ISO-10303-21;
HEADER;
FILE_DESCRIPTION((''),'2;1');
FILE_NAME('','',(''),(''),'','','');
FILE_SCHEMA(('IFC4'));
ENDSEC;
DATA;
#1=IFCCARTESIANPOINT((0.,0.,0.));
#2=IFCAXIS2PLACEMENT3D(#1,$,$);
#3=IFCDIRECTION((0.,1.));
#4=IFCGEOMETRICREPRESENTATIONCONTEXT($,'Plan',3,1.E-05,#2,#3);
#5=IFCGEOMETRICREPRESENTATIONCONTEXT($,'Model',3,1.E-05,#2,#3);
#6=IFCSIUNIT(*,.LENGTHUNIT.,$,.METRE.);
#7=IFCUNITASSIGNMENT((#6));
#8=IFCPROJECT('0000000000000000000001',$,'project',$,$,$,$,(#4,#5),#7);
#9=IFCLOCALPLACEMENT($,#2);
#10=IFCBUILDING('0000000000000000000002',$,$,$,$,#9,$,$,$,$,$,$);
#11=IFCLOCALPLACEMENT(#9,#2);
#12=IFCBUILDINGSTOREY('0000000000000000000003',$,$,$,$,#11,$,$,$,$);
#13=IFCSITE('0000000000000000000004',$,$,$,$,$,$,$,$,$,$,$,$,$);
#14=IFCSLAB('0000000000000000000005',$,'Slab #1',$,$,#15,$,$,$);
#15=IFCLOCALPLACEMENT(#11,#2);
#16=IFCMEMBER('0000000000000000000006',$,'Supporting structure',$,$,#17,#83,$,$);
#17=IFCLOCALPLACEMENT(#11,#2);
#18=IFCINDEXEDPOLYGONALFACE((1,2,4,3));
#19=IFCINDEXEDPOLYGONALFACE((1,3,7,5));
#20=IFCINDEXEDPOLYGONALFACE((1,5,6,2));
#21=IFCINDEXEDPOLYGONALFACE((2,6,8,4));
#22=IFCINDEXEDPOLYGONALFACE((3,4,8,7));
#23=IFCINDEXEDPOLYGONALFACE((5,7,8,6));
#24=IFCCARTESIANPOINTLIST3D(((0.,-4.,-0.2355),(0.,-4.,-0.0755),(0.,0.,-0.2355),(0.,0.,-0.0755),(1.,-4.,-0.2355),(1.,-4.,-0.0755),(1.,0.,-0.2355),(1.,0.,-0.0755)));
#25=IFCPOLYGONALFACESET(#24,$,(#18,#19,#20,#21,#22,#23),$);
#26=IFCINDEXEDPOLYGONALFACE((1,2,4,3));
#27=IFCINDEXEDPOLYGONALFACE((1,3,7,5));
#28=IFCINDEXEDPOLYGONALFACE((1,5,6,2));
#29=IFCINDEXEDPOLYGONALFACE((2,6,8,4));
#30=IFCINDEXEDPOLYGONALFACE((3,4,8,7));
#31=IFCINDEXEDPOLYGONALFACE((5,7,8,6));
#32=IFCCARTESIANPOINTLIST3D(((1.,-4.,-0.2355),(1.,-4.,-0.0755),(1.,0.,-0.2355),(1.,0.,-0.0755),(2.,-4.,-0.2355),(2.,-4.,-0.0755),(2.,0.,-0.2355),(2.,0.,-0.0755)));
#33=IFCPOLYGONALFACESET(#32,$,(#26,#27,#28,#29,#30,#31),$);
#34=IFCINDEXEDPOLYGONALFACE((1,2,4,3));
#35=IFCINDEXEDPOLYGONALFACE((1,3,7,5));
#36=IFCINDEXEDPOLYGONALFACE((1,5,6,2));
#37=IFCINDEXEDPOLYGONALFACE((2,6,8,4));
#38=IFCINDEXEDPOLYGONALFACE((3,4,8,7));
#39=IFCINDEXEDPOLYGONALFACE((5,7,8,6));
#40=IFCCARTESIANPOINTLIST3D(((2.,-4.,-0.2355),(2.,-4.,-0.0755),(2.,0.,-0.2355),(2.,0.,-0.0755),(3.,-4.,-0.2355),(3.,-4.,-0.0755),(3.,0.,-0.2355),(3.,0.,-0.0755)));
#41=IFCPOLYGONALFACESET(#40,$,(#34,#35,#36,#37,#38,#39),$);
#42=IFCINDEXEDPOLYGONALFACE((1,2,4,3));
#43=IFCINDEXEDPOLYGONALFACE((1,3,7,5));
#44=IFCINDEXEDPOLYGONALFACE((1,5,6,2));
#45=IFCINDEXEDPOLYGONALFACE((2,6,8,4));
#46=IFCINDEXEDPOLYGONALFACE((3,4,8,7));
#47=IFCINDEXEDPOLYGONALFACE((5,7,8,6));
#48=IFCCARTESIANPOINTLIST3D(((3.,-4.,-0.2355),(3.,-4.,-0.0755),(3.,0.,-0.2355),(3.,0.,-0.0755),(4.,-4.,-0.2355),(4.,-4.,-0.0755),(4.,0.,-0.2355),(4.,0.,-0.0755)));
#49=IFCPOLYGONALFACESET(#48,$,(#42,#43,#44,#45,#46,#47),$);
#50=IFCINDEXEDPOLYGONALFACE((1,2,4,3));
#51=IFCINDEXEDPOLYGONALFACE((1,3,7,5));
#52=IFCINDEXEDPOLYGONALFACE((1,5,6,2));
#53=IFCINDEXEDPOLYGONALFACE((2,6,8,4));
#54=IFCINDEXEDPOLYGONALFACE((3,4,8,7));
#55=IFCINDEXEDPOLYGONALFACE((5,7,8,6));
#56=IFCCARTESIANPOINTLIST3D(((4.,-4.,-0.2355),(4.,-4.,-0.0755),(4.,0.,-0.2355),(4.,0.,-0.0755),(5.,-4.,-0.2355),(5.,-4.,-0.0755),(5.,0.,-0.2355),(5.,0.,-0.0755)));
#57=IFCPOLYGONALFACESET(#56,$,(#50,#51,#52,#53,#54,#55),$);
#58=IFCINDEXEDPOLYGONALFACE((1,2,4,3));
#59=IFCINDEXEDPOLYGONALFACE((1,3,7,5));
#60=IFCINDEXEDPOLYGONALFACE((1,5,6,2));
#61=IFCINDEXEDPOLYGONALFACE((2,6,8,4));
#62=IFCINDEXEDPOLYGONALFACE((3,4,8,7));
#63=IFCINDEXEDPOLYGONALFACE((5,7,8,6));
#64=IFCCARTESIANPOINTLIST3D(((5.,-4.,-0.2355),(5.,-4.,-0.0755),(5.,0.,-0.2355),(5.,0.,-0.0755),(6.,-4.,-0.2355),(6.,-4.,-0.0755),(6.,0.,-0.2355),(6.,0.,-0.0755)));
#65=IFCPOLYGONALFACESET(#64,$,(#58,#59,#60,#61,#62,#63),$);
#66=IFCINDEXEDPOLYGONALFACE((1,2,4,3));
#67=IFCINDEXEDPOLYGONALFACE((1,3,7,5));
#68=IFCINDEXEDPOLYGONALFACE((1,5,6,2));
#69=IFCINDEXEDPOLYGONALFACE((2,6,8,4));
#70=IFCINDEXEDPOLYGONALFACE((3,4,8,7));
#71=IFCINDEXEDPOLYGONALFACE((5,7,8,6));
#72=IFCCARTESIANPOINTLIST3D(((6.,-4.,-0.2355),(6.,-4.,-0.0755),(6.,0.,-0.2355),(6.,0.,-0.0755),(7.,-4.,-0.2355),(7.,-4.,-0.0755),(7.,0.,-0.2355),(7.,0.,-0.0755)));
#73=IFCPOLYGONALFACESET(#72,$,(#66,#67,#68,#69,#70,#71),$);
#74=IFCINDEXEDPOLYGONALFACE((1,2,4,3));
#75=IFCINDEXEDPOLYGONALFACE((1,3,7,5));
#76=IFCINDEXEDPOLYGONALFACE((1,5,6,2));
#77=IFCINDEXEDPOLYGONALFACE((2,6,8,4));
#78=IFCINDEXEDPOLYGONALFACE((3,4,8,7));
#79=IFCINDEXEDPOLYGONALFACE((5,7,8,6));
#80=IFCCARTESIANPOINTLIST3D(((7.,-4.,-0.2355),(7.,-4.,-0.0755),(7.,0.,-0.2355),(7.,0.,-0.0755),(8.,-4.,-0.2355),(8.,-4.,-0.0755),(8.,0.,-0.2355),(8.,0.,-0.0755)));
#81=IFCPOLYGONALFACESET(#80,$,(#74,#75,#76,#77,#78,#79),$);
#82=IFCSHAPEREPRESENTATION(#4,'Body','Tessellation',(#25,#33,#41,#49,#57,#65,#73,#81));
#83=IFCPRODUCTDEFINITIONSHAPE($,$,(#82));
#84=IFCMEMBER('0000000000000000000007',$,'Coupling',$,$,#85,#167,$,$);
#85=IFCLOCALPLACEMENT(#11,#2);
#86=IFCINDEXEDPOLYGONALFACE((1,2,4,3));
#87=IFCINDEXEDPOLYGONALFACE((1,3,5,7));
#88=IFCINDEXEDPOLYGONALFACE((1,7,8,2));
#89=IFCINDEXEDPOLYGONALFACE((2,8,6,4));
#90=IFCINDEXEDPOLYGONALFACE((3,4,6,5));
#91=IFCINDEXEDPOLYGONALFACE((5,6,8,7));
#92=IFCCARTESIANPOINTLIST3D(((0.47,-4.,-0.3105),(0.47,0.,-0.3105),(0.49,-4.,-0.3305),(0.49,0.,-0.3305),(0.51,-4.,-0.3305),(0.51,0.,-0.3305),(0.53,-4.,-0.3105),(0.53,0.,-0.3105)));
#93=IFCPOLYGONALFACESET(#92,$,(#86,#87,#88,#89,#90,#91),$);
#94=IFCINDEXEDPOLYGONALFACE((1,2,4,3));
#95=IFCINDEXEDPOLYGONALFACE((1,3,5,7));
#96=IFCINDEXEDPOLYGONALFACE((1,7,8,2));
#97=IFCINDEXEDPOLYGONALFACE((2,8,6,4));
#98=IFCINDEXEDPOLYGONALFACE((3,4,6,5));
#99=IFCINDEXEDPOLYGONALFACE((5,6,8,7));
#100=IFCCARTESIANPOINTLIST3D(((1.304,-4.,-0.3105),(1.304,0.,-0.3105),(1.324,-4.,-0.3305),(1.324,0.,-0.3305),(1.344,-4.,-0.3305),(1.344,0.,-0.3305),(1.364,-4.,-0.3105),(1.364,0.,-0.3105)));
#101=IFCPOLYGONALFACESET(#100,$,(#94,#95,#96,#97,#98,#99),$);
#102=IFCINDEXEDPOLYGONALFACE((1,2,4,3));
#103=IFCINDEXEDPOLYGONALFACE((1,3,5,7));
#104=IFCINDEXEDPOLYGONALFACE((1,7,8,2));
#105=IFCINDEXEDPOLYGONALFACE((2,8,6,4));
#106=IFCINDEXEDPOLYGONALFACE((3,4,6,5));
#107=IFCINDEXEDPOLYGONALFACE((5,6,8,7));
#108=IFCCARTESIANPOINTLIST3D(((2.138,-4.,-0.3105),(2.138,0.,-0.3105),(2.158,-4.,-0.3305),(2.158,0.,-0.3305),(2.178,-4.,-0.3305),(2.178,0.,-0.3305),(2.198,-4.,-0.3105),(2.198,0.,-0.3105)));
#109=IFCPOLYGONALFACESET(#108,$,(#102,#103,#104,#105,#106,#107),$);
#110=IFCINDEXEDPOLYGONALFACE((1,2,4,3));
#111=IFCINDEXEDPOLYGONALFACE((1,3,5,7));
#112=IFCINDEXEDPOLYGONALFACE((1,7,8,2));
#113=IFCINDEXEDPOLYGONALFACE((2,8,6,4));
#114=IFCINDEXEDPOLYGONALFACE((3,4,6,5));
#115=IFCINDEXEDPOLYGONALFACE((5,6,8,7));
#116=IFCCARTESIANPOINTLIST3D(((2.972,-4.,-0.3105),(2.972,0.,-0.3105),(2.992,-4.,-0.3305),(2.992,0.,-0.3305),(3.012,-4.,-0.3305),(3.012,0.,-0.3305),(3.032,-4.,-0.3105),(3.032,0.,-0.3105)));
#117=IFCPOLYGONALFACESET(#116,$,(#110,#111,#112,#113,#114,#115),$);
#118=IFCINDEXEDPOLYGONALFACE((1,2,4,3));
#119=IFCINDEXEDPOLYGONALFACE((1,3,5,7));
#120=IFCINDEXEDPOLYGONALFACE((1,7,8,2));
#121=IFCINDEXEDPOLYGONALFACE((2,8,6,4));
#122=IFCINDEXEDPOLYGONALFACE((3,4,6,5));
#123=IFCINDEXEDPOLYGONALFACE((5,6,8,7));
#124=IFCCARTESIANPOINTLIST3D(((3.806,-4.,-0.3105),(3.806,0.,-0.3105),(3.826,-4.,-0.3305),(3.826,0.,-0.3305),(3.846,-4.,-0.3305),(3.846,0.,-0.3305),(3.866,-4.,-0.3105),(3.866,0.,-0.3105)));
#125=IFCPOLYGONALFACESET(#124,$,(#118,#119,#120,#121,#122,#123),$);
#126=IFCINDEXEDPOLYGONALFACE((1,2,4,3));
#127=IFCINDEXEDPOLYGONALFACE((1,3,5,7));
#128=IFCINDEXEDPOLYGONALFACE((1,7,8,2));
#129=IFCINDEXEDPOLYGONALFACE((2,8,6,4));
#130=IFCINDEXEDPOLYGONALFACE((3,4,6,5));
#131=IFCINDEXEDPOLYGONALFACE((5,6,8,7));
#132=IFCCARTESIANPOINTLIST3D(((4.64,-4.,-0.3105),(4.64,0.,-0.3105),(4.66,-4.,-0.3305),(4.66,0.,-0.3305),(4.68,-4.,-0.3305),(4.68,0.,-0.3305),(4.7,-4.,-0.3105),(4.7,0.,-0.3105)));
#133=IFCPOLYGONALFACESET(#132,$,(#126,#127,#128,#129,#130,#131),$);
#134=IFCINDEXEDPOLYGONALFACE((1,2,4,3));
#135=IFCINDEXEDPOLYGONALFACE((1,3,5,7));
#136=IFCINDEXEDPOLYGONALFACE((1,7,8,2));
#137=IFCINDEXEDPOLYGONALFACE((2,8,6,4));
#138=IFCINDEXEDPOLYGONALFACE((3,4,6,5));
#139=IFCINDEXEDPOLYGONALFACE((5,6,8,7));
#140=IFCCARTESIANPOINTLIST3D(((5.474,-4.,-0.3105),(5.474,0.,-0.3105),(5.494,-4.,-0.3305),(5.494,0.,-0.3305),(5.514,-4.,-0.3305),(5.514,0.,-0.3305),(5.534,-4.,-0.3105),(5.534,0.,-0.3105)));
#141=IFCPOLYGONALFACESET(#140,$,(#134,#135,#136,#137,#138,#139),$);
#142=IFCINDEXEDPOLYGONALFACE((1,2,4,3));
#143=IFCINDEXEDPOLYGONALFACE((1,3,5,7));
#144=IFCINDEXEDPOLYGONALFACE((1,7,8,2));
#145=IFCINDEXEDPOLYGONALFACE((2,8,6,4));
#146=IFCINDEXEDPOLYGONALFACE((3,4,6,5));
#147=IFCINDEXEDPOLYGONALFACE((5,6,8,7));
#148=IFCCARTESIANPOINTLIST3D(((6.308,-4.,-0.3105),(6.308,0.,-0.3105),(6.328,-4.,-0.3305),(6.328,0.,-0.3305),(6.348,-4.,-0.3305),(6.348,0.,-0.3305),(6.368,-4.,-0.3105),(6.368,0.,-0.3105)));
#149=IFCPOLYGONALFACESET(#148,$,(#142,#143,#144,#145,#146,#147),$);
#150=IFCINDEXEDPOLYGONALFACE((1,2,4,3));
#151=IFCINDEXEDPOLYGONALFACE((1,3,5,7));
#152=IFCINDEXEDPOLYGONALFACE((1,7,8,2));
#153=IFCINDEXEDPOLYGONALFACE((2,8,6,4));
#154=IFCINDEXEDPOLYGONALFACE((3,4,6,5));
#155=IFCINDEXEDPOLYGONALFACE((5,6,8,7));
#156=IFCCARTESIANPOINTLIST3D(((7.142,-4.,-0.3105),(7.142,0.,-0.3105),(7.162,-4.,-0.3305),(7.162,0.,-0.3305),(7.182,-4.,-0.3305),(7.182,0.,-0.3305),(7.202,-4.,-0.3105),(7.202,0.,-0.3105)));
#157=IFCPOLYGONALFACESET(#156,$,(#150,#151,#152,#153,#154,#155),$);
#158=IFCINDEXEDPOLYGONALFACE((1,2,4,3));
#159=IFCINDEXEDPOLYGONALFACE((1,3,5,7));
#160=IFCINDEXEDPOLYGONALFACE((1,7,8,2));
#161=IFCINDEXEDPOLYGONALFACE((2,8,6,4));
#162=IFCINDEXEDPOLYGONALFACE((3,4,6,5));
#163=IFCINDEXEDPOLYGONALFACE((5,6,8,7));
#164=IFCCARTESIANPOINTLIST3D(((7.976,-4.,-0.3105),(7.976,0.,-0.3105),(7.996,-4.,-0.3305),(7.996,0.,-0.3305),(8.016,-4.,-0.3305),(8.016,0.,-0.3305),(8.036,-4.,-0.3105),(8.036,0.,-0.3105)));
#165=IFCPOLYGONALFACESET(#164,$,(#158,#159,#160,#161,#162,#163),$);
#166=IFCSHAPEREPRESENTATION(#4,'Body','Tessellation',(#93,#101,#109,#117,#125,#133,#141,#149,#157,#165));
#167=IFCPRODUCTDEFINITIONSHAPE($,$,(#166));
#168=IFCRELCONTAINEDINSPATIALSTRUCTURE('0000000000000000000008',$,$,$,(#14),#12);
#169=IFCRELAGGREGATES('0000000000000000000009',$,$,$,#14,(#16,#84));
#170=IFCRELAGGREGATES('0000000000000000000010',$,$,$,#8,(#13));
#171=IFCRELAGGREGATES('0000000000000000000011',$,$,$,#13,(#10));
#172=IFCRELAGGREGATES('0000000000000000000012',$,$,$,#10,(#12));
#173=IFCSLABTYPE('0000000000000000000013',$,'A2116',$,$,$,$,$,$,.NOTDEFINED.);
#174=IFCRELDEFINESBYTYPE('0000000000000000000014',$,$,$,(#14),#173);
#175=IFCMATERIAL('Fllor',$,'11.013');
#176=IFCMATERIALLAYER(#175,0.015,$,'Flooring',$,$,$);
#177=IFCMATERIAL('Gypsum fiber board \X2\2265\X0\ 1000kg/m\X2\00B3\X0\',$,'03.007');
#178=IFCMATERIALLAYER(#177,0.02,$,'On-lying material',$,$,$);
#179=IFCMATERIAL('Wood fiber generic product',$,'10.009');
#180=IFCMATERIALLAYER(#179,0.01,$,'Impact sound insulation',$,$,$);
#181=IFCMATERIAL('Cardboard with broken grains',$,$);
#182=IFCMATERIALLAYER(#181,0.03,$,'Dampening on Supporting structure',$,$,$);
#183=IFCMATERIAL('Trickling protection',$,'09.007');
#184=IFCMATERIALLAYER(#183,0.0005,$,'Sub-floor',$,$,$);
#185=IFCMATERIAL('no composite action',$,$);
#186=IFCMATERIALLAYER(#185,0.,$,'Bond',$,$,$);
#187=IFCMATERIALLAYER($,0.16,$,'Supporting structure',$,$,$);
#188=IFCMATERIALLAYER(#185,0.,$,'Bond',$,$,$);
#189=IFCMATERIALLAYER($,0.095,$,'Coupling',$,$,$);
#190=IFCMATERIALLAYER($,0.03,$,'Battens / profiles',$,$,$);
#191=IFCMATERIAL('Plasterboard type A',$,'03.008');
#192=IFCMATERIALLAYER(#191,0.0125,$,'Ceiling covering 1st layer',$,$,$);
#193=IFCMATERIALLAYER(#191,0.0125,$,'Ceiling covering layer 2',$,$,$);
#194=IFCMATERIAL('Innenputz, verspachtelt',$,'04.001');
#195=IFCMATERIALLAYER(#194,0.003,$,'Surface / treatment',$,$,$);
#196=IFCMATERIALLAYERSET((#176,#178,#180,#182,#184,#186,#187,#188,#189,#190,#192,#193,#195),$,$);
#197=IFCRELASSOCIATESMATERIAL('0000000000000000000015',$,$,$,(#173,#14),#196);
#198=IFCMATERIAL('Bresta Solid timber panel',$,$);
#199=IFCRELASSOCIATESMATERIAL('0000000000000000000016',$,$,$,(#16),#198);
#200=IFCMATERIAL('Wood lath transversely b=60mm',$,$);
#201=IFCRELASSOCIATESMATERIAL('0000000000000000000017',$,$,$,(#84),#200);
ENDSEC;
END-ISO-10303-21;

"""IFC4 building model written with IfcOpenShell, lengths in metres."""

from ifc_helpers import new_model, si_unit, direction, frame, frame_2d, origin, place, context, project, spatial, polyline, rectangle, outline, extrude, material, layer, layer_set, type_object, element, aggregate, save


model = new_model("IFC4")

# Units and contexts
plan_context = context("Plan", 3, precision=1e-05, world=origin(), true_north=direction((0.0, 1.0)))
model_context = context("Model", 3, precision=1e-05, world=origin(), true_north=direction((0.0, 1.0)))
ifc_project = project(units=[si_unit("LENGTHUNIT", "METRE")], contexts=[plan_context, model_context])

# Site, building, storey
site = spatial("IfcSite", under=ifc_project)
building_placement = place(None, origin())
building = spatial("IfcBuilding", under=site, at=building_placement)
storey_placement = place(building_placement, origin())
storey = spatial("IfcBuildingStorey", under=building, at=storey_placement)

# Slab, members
ifc_material_1 = material(Name="Fllor", Category="11.013")
ifc_layer_1 = layer(ifc_material_1, 0.015, Name="Flooring")
ifc_material_2 = material(Name="Gypsum fiber board ≥ 1000kg/m³", Category="03.007")
ifc_layer_2 = layer(ifc_material_2, 0.02, Name="On-lying material")
ifc_material_3 = material(Name="Wood fiber generic product", Category="10.009")
ifc_layer_3 = layer(ifc_material_3, 0.01, Name="Impact sound insulation")
ifc_material_4 = material(Name="Cardboard with broken grains")
ifc_layer_4 = layer(ifc_material_4, 0.03, Name="Dampening on Supporting structure")
ifc_material_5 = material(Name="Trickling protection", Category="09.007")
ifc_layer_5 = layer(ifc_material_5, 0.0005, Name="Sub-floor")
ifc_material_6 = material(Name="no composite action")
ifc_layer_6 = layer(ifc_material_6, 0.0, Name="Bond")
ifc_layer_7 = layer(None, 0.16, Name="Supporting structure")
ifc_layer_8 = layer(ifc_material_6, 0.0, Name="Bond")
ifc_layer_9 = layer(None, 0.095, Name="Coupling")
ifc_layer_10 = layer(None, 0.03, Name="Battens / profiles")
ifc_material_7 = material(Name="Plasterboard type A", Category="03.008")
ifc_layer_11 = layer(ifc_material_7, 0.0125, Name="Ceiling covering 1st layer")
ifc_layer_12 = layer(ifc_material_7, 0.0125, Name="Ceiling covering layer 2")
ifc_material_8 = material(Name="Innenputz, verspachtelt", Category="04.001")
ifc_layer_13 = layer(ifc_material_8, 0.003, Name="Surface / treatment")
ifc_layer_set = layer_set([ifc_layer_1, ifc_layer_2, ifc_layer_3, ifc_layer_4, ifc_layer_5, ifc_layer_6, ifc_layer_7, ifc_layer_8, ifc_layer_9, ifc_layer_10, ifc_layer_11, ifc_layer_12, ifc_layer_13])
slab_type = type_object("IfcSlabType", Name="A2116", PredefinedType="NOTDEFINED", material=ifc_layer_set)
slab_placement = place(None, frame((0.0, 0.0, 0.0), z_axis=(0.0, 0.0, -1.0), x_axis=(1.0, 0.0, 0.0)))
slab = element("IfcSlab", 1, at=slab_placement, inside=storey, type_object=slab_type, material=ifc_layer_set, Name="Slab #1")
ifc_material_9 = material(Name="Bresta Solid timber panel")
member_1_placement = place(slab_placement, origin())
member_1 = element("IfcMember", 2, at=member_1_placement, material=ifc_material_9, Name="Supporting structure", context=plan_context, shape_type="SweptSolid", body=[
    extrude(rectangle(XDim=1.0, YDim=0.16, at=frame_2d((0.5, 0.08), x_axis=(1.0, 0.0))), frame((0.0, 4.0, 0.0755), z_axis=(0.0, -1.0, 0.0), x_axis=(1.0, 0.0, 0.0)), (0.0, 0.0, 1.0), 4.0),
    extrude(rectangle(XDim=1.0, YDim=0.16, at=frame_2d((0.5, 0.08), x_axis=(1.0, 0.0))), frame((1.0, 4.0, 0.0755), z_axis=(0.0, -1.0, 0.0), x_axis=(1.0, 0.0, 0.0)), (0.0, 0.0, 1.0), 4.0),
    extrude(rectangle(XDim=1.0, YDim=0.16, at=frame_2d((0.5, 0.08), x_axis=(1.0, 0.0))), frame((2.0, 4.0, 0.0755), z_axis=(0.0, -1.0, 0.0), x_axis=(1.0, 0.0, 0.0)), (0.0, 0.0, 1.0), 4.0),
    extrude(rectangle(XDim=1.0, YDim=0.16, at=frame_2d((0.5, 0.08), x_axis=(1.0, 0.0))), frame((3.0, 4.0, 0.0755), z_axis=(0.0, -1.0, 0.0), x_axis=(1.0, 0.0, 0.0)), (0.0, 0.0, 1.0), 4.0),
    extrude(rectangle(XDim=1.0, YDim=0.16, at=frame_2d((0.5, 0.08), x_axis=(1.0, 0.0))), frame((4.0, 4.0, 0.0755), z_axis=(0.0, -1.0, 0.0), x_axis=(1.0, 0.0, 0.0)), (0.0, 0.0, 1.0), 4.0),
    extrude(rectangle(XDim=1.0, YDim=0.16, at=frame_2d((0.5, 0.08), x_axis=(1.0, 0.0))), frame((5.0, 4.0, 0.0755), z_axis=(0.0, -1.0, 0.0), x_axis=(1.0, 0.0, 0.0)), (0.0, 0.0, 1.0), 4.0),
    extrude(rectangle(XDim=1.0, YDim=0.16, at=frame_2d((0.5, 0.08), x_axis=(1.0, 0.0))), frame((6.0, 4.0, 0.0755), z_axis=(0.0, -1.0, 0.0), x_axis=(1.0, 0.0, 0.0)), (0.0, 0.0, 1.0), 4.0),
    extrude(rectangle(XDim=1.0, YDim=0.16, at=frame_2d((0.5, 0.08), x_axis=(1.0, 0.0))), frame((7.0, 4.0, 0.0755), z_axis=(0.0, -1.0, 0.0), x_axis=(1.0, 0.0, 0.0)), (0.0, 0.0, 1.0), 4.0),
])
ifc_material_10 = material(Name="Wood lath transversely b=60mm")
member_2_placement = place(slab_placement, origin())
member_2 = element("IfcMember", 3, at=member_2_placement, material=ifc_material_10, Name="Coupling", context=plan_context, shape_type="SweptSolid", body=[
    extrude(outline(polyline([(0.0, 0.0), (0.06, 0.0), (0.04, 0.02), (0.02, 0.02), (0.0, 0.0)])), frame((0.47, 4.0, 0.3105), z_axis=(0.0, -1.0, 0.0), x_axis=(1.0, 0.0, 0.0)), (0.0, 0.0, 1.0), 4.0),
    extrude(outline(polyline([(0.0, 0.0), (0.06, 0.0), (0.04, 0.02), (0.02, 0.02), (0.0, 0.0)])), frame((1.304, 4.0, 0.3105), z_axis=(0.0, -1.0, 0.0), x_axis=(1.0, 0.0, 0.0)), (0.0, 0.0, 1.0), 4.0),
    extrude(outline(polyline([(0.0, 0.0), (0.06, 0.0), (0.04, 0.02), (0.02, 0.02), (0.0, 0.0)])), frame((2.138, 4.0, 0.3105), z_axis=(0.0, -1.0, 0.0), x_axis=(1.0, 0.0, 0.0)), (0.0, 0.0, 1.0), 4.0),
    extrude(outline(polyline([(0.0, 0.0), (0.06, 0.0), (0.04, 0.02), (0.02, 0.02), (0.0, 0.0)])), frame((2.972, 4.0, 0.3105), z_axis=(0.0, -1.0, 0.0), x_axis=(1.0, 0.0, 0.0)), (0.0, 0.0, 1.0), 4.0),
    extrude(outline(polyline([(0.0, 0.0), (0.06, 0.0), (0.04, 0.02), (0.02, 0.02), (0.0, 0.0)])), frame((3.806, 4.0, 0.3105), z_axis=(0.0, -1.0, 0.0), x_axis=(1.0, 0.0, 0.0)), (0.0, 0.0, 1.0), 4.0),
    extrude(outline(polyline([(0.0, 0.0), (0.06, 0.0), (0.04, 0.02), (0.02, 0.02), (0.0, 0.0)])), frame((4.64, 4.0, 0.3105), z_axis=(0.0, -1.0, 0.0), x_axis=(1.0, 0.0, 0.0)), (0.0, 0.0, 1.0), 4.0),
    extrude(outline(polyline([(0.0, 0.0), (0.06, 0.0), (0.04, 0.02), (0.02, 0.02), (0.0, 0.0)])), frame((5.474, 4.0, 0.3105), z_axis=(0.0, -1.0, 0.0), x_axis=(1.0, 0.0, 0.0)), (0.0, 0.0, 1.0), 4.0),
    extrude(outline(polyline([(0.0, 0.0), (0.06, 0.0), (0.04, 0.02), (0.02, 0.02), (0.0, 0.0)])), frame((6.308, 4.0, 0.3105), z_axis=(0.0, -1.0, 0.0), x_axis=(1.0, 0.0, 0.0)), (0.0, 0.0, 1.0), 4.0),
    extrude(outline(polyline([(0.0, 0.0), (0.06, 0.0), (0.04, 0.02), (0.02, 0.02), (0.0, 0.0)])), frame((7.142, 4.0, 0.3105), z_axis=(0.0, -1.0, 0.0), x_axis=(1.0, 0.0, 0.0)), (0.0, 0.0, 1.0), 4.0),
    extrude(outline(polyline([(0.0, 0.0), (0.06, 0.0), (0.04, 0.02), (0.02, 0.02), (0.0, 0.0)])), frame((7.976, 4.0, 0.3105), z_axis=(0.0, -1.0, 0.0), x_axis=(1.0, 0.0, 0.0)), (0.0, 0.0, 1.0), 4.0),
])
aggregate(slab, [member_1, member_2])

save(model, "model.ifc")
